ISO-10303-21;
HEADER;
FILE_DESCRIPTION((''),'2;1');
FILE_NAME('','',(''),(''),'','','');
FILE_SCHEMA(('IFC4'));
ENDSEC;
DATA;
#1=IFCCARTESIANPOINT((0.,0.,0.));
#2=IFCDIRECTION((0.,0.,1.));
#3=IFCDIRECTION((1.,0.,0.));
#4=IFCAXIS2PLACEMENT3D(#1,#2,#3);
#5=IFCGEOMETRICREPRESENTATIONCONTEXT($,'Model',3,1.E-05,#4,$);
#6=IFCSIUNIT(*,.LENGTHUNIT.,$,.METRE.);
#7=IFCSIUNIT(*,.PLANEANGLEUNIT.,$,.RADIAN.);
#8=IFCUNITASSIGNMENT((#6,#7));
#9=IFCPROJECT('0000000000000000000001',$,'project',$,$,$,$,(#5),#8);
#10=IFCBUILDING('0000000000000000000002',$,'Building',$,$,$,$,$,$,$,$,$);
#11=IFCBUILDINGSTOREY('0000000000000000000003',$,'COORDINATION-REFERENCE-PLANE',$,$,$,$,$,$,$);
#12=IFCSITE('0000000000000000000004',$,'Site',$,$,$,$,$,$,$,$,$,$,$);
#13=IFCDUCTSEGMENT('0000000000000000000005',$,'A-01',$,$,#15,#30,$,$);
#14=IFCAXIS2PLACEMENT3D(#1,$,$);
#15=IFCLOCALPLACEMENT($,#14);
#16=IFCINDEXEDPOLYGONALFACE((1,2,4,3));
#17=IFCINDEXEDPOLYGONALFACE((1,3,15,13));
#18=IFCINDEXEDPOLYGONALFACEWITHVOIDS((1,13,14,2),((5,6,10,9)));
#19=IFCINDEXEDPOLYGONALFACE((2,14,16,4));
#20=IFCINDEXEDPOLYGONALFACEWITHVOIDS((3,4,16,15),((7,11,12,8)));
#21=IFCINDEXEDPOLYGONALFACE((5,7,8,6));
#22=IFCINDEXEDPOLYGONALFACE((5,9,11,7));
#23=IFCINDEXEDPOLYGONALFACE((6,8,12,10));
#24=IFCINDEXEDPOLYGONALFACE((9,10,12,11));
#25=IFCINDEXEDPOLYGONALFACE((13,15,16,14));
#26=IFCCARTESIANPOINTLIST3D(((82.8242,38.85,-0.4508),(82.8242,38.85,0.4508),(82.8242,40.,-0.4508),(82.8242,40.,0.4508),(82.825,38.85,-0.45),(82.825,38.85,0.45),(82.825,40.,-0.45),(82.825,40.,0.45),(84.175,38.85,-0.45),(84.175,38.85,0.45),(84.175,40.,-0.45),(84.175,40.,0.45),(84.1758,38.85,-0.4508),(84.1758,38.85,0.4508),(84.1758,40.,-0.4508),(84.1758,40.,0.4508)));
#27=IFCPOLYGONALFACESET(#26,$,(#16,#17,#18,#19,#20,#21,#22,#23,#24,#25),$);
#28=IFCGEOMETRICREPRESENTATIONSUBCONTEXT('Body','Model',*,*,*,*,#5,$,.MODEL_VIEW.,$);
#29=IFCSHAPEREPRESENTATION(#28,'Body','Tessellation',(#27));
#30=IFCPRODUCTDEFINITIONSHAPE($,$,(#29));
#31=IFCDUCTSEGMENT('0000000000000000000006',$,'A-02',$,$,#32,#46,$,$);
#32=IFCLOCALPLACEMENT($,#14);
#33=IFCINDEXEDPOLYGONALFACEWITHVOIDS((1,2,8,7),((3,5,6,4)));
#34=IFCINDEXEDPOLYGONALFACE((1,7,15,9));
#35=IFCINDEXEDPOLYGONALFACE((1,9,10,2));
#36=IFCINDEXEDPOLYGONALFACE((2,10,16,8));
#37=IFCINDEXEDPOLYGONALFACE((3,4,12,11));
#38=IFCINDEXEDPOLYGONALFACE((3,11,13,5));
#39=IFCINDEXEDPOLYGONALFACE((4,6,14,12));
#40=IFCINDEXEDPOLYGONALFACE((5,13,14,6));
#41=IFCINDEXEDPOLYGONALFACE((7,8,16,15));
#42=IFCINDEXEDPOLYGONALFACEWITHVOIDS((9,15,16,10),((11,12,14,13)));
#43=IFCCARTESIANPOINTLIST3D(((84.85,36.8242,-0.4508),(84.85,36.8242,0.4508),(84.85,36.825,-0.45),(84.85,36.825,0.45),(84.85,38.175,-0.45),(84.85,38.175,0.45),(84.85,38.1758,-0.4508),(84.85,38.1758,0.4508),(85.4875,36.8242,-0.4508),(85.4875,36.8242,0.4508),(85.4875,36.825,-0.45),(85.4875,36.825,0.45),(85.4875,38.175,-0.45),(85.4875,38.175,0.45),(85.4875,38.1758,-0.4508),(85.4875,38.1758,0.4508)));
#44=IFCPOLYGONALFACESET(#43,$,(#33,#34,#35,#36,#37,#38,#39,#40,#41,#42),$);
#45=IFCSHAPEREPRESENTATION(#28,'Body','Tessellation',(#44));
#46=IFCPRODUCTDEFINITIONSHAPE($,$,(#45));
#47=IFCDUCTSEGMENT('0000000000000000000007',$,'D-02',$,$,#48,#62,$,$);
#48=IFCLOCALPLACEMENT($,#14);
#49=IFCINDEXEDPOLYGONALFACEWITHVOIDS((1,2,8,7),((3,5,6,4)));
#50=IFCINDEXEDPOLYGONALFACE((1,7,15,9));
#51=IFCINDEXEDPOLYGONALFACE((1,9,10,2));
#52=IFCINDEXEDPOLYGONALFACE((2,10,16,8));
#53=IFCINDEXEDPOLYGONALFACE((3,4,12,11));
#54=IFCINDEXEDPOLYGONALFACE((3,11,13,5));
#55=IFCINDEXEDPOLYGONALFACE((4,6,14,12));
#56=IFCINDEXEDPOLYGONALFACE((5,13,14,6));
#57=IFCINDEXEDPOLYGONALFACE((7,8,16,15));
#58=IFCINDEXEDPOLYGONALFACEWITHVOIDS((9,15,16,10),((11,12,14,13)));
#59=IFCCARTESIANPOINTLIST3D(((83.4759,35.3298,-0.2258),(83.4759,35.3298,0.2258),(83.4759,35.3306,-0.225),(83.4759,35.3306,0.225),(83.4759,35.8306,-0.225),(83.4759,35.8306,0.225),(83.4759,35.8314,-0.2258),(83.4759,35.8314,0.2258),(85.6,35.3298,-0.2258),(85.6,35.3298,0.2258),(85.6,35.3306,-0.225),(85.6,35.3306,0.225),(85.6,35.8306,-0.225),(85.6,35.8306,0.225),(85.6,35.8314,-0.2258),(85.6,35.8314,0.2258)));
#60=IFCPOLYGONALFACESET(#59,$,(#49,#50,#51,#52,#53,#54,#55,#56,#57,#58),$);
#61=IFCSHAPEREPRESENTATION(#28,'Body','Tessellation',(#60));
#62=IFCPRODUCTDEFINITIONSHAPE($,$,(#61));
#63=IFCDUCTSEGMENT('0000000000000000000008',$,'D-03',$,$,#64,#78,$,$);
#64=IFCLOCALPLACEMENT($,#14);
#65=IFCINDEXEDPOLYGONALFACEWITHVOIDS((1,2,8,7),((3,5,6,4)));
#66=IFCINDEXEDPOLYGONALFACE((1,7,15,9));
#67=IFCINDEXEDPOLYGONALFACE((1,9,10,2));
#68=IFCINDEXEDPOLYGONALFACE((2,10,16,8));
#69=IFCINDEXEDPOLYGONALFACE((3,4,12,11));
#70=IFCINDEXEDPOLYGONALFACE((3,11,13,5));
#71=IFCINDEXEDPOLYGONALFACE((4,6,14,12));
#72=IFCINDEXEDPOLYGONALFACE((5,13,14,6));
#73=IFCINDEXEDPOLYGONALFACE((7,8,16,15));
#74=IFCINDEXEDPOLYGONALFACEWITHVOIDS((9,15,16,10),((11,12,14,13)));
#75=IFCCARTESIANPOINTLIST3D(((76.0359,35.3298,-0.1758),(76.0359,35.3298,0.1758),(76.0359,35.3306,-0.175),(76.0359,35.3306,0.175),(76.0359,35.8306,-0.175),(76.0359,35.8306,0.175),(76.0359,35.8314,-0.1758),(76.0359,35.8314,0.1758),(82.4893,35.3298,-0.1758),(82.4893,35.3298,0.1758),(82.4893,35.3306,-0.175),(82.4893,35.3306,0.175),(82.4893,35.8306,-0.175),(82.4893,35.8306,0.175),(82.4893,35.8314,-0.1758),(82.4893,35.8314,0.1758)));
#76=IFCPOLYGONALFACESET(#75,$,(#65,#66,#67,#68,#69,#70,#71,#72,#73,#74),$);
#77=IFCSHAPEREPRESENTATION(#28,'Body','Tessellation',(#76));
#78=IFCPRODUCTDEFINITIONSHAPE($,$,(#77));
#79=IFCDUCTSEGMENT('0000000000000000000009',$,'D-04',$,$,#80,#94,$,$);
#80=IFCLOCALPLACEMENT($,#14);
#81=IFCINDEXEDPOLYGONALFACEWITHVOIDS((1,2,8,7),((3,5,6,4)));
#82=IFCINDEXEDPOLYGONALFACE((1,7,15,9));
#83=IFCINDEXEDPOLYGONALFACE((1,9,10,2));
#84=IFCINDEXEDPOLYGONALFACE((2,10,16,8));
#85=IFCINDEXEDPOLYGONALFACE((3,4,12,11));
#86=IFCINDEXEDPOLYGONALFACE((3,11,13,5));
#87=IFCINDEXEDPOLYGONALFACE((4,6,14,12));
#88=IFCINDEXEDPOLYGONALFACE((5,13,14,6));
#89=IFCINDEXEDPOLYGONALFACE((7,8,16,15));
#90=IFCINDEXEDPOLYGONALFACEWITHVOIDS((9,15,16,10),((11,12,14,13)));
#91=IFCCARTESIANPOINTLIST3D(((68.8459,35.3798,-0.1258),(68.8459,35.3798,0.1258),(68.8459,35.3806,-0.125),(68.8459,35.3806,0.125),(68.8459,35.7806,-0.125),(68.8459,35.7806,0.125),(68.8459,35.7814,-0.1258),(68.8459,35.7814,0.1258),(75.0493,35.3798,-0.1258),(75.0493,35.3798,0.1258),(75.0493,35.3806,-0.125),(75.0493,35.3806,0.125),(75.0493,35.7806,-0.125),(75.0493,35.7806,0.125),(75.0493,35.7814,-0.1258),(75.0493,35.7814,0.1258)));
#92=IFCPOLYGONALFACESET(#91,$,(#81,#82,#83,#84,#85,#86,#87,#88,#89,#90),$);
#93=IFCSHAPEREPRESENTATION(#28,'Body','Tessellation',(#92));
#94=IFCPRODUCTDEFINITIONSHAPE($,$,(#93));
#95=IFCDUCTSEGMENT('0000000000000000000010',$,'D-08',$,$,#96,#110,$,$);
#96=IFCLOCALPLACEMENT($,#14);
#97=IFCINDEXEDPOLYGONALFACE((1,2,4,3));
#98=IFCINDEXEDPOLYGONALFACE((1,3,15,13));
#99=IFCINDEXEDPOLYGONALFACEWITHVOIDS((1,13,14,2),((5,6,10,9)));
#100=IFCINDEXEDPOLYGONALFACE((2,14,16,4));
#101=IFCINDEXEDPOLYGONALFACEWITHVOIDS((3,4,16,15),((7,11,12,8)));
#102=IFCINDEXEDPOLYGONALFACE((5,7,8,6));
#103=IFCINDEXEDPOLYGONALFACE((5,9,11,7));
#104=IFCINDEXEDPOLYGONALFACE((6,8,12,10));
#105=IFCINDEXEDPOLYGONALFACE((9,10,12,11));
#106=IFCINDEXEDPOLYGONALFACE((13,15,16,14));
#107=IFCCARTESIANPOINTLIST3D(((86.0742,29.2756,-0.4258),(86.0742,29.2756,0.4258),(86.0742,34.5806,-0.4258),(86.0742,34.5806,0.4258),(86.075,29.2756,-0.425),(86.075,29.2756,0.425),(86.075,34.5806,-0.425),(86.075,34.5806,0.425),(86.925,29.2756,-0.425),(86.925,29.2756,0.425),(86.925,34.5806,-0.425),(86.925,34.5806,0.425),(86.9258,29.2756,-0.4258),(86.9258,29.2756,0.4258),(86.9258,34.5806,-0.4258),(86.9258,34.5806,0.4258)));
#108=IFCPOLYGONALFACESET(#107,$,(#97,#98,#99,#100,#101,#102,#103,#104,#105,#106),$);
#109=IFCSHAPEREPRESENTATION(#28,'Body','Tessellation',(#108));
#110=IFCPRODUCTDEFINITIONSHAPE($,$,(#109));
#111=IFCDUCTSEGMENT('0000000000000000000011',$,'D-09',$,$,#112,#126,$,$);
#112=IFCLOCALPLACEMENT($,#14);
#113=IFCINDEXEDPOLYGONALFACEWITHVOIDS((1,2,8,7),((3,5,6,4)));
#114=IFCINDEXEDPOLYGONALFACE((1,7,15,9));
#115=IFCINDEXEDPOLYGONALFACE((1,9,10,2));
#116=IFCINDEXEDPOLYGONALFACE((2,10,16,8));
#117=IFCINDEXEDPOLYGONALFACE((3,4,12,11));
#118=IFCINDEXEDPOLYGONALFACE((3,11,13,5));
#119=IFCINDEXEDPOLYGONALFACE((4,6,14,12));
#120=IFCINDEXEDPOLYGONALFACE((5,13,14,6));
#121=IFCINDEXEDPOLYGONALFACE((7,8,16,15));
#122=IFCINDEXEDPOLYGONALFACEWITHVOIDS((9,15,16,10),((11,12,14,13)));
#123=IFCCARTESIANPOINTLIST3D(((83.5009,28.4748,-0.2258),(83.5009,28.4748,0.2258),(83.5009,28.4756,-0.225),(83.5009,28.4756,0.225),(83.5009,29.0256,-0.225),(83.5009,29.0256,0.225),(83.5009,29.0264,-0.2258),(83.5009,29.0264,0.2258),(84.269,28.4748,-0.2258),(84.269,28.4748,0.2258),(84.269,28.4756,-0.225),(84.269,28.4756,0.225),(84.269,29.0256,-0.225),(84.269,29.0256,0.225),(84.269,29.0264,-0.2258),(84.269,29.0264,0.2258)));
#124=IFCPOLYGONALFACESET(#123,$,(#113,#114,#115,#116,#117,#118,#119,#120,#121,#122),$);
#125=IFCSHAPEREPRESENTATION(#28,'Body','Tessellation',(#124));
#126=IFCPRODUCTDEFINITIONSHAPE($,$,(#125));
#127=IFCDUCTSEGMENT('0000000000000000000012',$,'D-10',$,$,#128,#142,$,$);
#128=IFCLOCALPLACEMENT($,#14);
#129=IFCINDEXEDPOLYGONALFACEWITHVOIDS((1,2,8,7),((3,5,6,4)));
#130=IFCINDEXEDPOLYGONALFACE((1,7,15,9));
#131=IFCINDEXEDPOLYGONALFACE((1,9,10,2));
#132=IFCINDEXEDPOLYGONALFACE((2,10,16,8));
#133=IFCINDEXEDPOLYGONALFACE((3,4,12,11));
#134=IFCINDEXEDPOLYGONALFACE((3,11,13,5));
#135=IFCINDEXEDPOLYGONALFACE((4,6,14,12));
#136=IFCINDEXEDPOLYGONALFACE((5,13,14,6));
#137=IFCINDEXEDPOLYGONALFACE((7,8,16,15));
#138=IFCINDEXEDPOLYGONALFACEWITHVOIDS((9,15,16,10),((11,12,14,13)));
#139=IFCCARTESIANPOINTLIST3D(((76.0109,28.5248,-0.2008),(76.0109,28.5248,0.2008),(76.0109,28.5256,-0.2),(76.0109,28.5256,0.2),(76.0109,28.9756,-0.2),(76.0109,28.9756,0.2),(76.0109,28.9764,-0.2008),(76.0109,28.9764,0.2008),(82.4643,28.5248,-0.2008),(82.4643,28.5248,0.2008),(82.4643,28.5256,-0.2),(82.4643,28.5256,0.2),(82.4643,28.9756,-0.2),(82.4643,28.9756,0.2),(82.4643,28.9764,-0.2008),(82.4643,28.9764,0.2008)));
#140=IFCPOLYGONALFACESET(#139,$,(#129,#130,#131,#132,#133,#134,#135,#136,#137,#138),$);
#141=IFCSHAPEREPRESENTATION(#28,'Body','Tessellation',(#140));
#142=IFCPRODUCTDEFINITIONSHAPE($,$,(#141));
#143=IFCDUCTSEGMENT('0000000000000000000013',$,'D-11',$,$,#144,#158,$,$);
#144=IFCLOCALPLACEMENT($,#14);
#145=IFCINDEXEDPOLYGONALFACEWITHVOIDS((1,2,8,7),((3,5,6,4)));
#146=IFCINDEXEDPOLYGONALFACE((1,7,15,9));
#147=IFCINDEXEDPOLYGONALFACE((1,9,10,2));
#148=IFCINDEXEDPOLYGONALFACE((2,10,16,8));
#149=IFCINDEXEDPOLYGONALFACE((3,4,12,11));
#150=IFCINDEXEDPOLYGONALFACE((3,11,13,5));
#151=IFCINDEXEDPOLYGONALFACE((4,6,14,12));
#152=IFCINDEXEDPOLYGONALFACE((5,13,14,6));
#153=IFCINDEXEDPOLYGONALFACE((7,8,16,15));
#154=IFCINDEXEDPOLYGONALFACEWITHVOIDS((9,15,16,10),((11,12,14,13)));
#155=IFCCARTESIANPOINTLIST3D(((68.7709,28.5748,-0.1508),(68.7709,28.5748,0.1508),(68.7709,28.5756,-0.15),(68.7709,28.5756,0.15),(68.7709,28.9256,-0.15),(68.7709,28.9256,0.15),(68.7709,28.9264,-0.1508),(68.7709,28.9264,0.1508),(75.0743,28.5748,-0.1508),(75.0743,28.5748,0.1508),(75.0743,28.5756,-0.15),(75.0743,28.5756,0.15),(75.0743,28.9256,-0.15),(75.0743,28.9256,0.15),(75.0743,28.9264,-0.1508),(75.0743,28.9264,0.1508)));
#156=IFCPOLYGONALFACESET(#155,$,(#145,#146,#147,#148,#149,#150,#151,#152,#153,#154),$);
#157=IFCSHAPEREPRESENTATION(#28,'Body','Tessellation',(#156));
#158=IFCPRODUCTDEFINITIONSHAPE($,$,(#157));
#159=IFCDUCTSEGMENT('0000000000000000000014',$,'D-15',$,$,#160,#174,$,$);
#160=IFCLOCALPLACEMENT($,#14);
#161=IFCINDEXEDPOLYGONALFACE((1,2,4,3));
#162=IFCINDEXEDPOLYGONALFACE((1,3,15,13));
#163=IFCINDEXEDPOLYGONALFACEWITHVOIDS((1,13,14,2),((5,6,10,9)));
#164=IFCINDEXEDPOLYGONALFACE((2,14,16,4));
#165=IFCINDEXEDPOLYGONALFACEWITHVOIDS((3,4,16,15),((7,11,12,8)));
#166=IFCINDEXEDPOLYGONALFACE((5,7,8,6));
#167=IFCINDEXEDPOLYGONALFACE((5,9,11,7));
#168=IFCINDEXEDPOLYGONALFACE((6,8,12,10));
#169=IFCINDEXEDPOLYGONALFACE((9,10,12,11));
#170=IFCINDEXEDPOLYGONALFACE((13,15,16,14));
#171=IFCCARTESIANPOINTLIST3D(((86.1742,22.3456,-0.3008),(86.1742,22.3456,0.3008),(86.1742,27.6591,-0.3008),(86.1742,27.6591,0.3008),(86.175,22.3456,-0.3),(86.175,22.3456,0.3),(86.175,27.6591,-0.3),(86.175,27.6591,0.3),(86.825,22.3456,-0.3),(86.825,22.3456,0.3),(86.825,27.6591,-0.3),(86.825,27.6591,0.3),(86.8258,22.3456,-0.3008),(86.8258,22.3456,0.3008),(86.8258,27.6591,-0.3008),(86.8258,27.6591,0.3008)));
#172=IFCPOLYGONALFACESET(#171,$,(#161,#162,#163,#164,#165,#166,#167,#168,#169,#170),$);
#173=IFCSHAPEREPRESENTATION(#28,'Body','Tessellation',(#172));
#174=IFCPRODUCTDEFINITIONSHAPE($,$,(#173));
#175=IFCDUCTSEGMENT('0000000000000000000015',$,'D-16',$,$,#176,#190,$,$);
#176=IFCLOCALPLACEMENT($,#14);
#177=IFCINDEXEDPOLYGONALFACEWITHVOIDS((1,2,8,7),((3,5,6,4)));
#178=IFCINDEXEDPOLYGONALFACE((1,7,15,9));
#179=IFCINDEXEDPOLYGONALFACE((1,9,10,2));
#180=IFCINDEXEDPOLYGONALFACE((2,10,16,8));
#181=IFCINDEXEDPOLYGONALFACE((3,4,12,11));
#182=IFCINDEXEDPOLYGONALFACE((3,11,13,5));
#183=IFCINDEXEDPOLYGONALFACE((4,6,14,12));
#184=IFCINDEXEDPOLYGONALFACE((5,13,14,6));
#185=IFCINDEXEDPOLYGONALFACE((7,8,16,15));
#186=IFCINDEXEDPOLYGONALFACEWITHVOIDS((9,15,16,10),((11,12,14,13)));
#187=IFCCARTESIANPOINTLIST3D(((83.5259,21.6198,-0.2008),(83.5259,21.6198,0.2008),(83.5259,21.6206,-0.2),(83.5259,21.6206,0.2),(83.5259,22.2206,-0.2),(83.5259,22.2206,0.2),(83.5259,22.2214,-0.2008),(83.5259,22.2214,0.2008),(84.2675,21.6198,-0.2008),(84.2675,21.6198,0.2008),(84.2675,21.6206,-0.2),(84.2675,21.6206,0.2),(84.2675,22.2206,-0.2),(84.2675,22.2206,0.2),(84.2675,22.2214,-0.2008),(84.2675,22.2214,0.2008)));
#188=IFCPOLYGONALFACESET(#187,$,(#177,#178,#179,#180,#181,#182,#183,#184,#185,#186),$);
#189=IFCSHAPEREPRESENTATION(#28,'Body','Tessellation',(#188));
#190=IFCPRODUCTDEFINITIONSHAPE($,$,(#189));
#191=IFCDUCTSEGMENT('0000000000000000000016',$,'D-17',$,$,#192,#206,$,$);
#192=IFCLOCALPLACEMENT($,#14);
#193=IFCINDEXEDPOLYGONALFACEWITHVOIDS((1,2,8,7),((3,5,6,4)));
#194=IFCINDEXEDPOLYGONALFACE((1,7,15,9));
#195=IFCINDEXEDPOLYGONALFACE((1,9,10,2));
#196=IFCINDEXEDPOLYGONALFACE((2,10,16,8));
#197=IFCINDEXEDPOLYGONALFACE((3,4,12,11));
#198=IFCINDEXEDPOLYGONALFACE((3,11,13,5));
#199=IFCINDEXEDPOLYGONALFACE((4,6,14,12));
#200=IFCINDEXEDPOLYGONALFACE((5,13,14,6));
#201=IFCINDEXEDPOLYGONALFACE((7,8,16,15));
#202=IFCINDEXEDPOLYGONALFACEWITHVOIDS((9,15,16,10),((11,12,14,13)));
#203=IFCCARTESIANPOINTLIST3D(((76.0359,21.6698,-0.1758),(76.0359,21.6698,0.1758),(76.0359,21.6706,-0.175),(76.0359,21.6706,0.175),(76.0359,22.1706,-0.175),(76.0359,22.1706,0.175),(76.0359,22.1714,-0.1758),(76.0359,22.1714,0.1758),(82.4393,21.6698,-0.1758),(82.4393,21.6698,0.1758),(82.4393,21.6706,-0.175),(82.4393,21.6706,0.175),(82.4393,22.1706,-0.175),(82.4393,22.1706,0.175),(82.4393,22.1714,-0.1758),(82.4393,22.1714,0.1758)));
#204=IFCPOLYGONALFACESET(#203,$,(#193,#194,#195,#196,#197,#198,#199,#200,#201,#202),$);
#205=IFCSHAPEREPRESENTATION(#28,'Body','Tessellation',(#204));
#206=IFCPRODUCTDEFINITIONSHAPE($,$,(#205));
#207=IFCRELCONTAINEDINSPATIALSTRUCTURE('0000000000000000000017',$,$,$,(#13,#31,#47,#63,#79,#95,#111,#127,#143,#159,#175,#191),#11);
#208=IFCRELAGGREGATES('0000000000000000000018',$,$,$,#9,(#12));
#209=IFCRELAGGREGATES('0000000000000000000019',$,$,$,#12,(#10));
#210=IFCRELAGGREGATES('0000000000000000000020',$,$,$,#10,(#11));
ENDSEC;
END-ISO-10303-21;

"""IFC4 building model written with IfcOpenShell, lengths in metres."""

from ifc_helpers import new_model, si_unit, frame, origin, origin_with_axes, place, context, subcontext, project, spatial, hollow_rectangle, extrude, element, save


model = new_model("IFC4")

# Units and contexts
model_context = context("Model", 3, precision=1e-05, world=origin_with_axes())
body_context = subcontext(model_context, "Body", "Model", "MODEL_VIEW")
ifc_project = project(units=[si_unit("LENGTHUNIT", "METRE"), si_unit("PLANEANGLEUNIT", "RADIAN")], contexts=[model_context])

# Site, building, storey
site = spatial("IfcSite", under=ifc_project, Name="Site")
building = spatial("IfcBuilding", under=site, Name="Building")
storey = spatial("IfcBuildingStorey", under=building, Name="COORDINATION-REFERENCE-PLANE")

# Duct segments
duct_segment_1_placement = place(None, frame((83.5, 38.85, 0.0), z_axis=(0.0, 1.0, 0.0), x_axis=(1.0, 0.0, 0.0)))
element("IfcDuctSegment", 1, at=duct_segment_1_placement, inside=storey, Name="A-01", context=body_context, shape_type="SweptSolid", body=[
    extrude(hollow_rectangle(XDim=1.3516, YDim=0.9016, WallThickness=0.0008), origin(), (0.0, 0.0, 1.0), 1.15),
])
duct_segment_2_placement = place(None, frame((84.85, 37.5, 0.0), z_axis=(1.0, 0.0, 0.0), x_axis=(0.0, 1.0, 0.0)))
element("IfcDuctSegment", 2, at=duct_segment_2_placement, inside=storey, Name="A-02", context=body_context, shape_type="SweptSolid", body=[
    extrude(hollow_rectangle(XDim=1.3516, YDim=0.9016, WallThickness=0.0008), origin(), (0.0, 0.0, 1.0), 0.6375),
])
duct_segment_3_placement = place(None, frame((83.4759, 35.5806, 0.0), z_axis=(1.0, 0.0, 0.0), x_axis=(0.0, 1.0, 0.0)))
element("IfcDuctSegment", 3, at=duct_segment_3_placement, inside=storey, Name="D-02", context=body_context, shape_type="SweptSolid", body=[
    extrude(hollow_rectangle(XDim=0.5016, YDim=0.4516, WallThickness=0.0008), origin(), (0.0, 0.0, 1.0), 2.1241),
])
duct_segment_4_placement = place(None, frame((76.0359, 35.5806, 0.0), z_axis=(1.0, 0.0, 0.0), x_axis=(0.0, 1.0, 0.0)))
element("IfcDuctSegment", 4, at=duct_segment_4_placement, inside=storey, Name="D-03", context=body_context, shape_type="SweptSolid", body=[
    extrude(hollow_rectangle(XDim=0.5016, YDim=0.3516, WallThickness=0.0008), origin(), (0.0, 0.0, 1.0), 6.4534),
])
duct_segment_5_placement = place(None, frame((68.8459, 35.5806, 0.0), z_axis=(1.0, 0.0, 0.0), x_axis=(0.0, 1.0, 0.0)))
element("IfcDuctSegment", 5, at=duct_segment_5_placement, inside=storey, Name="D-04", context=body_context, shape_type="SweptSolid", body=[
    extrude(hollow_rectangle(XDim=0.4016, YDim=0.2516, WallThickness=0.0008), origin(), (0.0, 0.0, 1.0), 6.2034),
])
duct_segment_6_placement = place(None, frame((86.5, 29.2756, 0.0), z_axis=(0.0, 1.0, 0.0), x_axis=(1.0, 0.0, 0.0)))
element("IfcDuctSegment", 6, at=duct_segment_6_placement, inside=storey, Name="D-08", context=body_context, shape_type="SweptSolid", body=[
    extrude(hollow_rectangle(XDim=0.8516, YDim=0.8516, WallThickness=0.0008), origin(), (0.0, 0.0, 1.0), 5.305),
])
duct_segment_7_placement = place(None, frame((83.5009, 28.7506, 0.0), z_axis=(1.0, 0.0, 0.0), x_axis=(0.0, 1.0, 0.0)))
element("IfcDuctSegment", 7, at=duct_segment_7_placement, inside=storey, Name="D-09", context=body_context, shape_type="SweptSolid", body=[
    extrude(hollow_rectangle(XDim=0.5516, YDim=0.4516, WallThickness=0.0008), origin(), (0.0, 0.0, 1.0), 0.7681),
])
duct_segment_8_placement = place(None, frame((76.0109, 28.7506, 0.0), z_axis=(1.0, 0.0, 0.0), x_axis=(0.0, 1.0, 0.0)))
element("IfcDuctSegment", 8, at=duct_segment_8_placement, inside=storey, Name="D-10", context=body_context, shape_type="SweptSolid", body=[
    extrude(hollow_rectangle(XDim=0.4516, YDim=0.4016, WallThickness=0.0008), origin(), (0.0, 0.0, 1.0), 6.4534),
])
duct_segment_9_placement = place(None, frame((68.7709, 28.7506, 0.0), z_axis=(1.0, 0.0, 0.0), x_axis=(0.0, 1.0, 0.0)))
element("IfcDuctSegment", 9, at=duct_segment_9_placement, inside=storey, Name="D-11", context=body_context, shape_type="SweptSolid", body=[
    extrude(hollow_rectangle(XDim=0.3516, YDim=0.3016, WallThickness=0.0008), origin(), (0.0, 0.0, 1.0), 6.3034),
])
duct_segment_10_placement = place(None, frame((86.5, 22.3456, 0.0), z_axis=(0.0, 1.0, 0.0), x_axis=(1.0, 0.0, 0.0)))
element("IfcDuctSegment", 10, at=duct_segment_10_placement, inside=storey, Name="D-15", context=body_context, shape_type="SweptSolid", body=[
    extrude(hollow_rectangle(XDim=0.6516, YDim=0.6016, WallThickness=0.0008), origin(), (0.0, 0.0, 1.0), 5.3135),
])
duct_segment_11_placement = place(None, frame((83.5259, 21.9206, 0.0), z_axis=(1.0, 0.0, 0.0), x_axis=(0.0, 1.0, 0.0)))
element("IfcDuctSegment", 11, at=duct_segment_11_placement, inside=storey, Name="D-16", context=body_context, shape_type="SweptSolid", body=[
    extrude(hollow_rectangle(XDim=0.6016, YDim=0.4016, WallThickness=0.0008), origin(), (0.0, 0.0, 1.0), 0.7416),
])
duct_segment_12_placement = place(None, frame((76.0359, 21.9206, 0.0), z_axis=(1.0, 0.0, 0.0), x_axis=(0.0, 1.0, 0.0)))
element("IfcDuctSegment", 12, at=duct_segment_12_placement, inside=storey, Name="D-17", context=body_context, shape_type="SweptSolid", body=[
    extrude(hollow_rectangle(XDim=0.5016, YDim=0.3516, WallThickness=0.0008), origin(), (0.0, 0.0, 1.0), 6.4034),
])

save(model, "model.ifc")
